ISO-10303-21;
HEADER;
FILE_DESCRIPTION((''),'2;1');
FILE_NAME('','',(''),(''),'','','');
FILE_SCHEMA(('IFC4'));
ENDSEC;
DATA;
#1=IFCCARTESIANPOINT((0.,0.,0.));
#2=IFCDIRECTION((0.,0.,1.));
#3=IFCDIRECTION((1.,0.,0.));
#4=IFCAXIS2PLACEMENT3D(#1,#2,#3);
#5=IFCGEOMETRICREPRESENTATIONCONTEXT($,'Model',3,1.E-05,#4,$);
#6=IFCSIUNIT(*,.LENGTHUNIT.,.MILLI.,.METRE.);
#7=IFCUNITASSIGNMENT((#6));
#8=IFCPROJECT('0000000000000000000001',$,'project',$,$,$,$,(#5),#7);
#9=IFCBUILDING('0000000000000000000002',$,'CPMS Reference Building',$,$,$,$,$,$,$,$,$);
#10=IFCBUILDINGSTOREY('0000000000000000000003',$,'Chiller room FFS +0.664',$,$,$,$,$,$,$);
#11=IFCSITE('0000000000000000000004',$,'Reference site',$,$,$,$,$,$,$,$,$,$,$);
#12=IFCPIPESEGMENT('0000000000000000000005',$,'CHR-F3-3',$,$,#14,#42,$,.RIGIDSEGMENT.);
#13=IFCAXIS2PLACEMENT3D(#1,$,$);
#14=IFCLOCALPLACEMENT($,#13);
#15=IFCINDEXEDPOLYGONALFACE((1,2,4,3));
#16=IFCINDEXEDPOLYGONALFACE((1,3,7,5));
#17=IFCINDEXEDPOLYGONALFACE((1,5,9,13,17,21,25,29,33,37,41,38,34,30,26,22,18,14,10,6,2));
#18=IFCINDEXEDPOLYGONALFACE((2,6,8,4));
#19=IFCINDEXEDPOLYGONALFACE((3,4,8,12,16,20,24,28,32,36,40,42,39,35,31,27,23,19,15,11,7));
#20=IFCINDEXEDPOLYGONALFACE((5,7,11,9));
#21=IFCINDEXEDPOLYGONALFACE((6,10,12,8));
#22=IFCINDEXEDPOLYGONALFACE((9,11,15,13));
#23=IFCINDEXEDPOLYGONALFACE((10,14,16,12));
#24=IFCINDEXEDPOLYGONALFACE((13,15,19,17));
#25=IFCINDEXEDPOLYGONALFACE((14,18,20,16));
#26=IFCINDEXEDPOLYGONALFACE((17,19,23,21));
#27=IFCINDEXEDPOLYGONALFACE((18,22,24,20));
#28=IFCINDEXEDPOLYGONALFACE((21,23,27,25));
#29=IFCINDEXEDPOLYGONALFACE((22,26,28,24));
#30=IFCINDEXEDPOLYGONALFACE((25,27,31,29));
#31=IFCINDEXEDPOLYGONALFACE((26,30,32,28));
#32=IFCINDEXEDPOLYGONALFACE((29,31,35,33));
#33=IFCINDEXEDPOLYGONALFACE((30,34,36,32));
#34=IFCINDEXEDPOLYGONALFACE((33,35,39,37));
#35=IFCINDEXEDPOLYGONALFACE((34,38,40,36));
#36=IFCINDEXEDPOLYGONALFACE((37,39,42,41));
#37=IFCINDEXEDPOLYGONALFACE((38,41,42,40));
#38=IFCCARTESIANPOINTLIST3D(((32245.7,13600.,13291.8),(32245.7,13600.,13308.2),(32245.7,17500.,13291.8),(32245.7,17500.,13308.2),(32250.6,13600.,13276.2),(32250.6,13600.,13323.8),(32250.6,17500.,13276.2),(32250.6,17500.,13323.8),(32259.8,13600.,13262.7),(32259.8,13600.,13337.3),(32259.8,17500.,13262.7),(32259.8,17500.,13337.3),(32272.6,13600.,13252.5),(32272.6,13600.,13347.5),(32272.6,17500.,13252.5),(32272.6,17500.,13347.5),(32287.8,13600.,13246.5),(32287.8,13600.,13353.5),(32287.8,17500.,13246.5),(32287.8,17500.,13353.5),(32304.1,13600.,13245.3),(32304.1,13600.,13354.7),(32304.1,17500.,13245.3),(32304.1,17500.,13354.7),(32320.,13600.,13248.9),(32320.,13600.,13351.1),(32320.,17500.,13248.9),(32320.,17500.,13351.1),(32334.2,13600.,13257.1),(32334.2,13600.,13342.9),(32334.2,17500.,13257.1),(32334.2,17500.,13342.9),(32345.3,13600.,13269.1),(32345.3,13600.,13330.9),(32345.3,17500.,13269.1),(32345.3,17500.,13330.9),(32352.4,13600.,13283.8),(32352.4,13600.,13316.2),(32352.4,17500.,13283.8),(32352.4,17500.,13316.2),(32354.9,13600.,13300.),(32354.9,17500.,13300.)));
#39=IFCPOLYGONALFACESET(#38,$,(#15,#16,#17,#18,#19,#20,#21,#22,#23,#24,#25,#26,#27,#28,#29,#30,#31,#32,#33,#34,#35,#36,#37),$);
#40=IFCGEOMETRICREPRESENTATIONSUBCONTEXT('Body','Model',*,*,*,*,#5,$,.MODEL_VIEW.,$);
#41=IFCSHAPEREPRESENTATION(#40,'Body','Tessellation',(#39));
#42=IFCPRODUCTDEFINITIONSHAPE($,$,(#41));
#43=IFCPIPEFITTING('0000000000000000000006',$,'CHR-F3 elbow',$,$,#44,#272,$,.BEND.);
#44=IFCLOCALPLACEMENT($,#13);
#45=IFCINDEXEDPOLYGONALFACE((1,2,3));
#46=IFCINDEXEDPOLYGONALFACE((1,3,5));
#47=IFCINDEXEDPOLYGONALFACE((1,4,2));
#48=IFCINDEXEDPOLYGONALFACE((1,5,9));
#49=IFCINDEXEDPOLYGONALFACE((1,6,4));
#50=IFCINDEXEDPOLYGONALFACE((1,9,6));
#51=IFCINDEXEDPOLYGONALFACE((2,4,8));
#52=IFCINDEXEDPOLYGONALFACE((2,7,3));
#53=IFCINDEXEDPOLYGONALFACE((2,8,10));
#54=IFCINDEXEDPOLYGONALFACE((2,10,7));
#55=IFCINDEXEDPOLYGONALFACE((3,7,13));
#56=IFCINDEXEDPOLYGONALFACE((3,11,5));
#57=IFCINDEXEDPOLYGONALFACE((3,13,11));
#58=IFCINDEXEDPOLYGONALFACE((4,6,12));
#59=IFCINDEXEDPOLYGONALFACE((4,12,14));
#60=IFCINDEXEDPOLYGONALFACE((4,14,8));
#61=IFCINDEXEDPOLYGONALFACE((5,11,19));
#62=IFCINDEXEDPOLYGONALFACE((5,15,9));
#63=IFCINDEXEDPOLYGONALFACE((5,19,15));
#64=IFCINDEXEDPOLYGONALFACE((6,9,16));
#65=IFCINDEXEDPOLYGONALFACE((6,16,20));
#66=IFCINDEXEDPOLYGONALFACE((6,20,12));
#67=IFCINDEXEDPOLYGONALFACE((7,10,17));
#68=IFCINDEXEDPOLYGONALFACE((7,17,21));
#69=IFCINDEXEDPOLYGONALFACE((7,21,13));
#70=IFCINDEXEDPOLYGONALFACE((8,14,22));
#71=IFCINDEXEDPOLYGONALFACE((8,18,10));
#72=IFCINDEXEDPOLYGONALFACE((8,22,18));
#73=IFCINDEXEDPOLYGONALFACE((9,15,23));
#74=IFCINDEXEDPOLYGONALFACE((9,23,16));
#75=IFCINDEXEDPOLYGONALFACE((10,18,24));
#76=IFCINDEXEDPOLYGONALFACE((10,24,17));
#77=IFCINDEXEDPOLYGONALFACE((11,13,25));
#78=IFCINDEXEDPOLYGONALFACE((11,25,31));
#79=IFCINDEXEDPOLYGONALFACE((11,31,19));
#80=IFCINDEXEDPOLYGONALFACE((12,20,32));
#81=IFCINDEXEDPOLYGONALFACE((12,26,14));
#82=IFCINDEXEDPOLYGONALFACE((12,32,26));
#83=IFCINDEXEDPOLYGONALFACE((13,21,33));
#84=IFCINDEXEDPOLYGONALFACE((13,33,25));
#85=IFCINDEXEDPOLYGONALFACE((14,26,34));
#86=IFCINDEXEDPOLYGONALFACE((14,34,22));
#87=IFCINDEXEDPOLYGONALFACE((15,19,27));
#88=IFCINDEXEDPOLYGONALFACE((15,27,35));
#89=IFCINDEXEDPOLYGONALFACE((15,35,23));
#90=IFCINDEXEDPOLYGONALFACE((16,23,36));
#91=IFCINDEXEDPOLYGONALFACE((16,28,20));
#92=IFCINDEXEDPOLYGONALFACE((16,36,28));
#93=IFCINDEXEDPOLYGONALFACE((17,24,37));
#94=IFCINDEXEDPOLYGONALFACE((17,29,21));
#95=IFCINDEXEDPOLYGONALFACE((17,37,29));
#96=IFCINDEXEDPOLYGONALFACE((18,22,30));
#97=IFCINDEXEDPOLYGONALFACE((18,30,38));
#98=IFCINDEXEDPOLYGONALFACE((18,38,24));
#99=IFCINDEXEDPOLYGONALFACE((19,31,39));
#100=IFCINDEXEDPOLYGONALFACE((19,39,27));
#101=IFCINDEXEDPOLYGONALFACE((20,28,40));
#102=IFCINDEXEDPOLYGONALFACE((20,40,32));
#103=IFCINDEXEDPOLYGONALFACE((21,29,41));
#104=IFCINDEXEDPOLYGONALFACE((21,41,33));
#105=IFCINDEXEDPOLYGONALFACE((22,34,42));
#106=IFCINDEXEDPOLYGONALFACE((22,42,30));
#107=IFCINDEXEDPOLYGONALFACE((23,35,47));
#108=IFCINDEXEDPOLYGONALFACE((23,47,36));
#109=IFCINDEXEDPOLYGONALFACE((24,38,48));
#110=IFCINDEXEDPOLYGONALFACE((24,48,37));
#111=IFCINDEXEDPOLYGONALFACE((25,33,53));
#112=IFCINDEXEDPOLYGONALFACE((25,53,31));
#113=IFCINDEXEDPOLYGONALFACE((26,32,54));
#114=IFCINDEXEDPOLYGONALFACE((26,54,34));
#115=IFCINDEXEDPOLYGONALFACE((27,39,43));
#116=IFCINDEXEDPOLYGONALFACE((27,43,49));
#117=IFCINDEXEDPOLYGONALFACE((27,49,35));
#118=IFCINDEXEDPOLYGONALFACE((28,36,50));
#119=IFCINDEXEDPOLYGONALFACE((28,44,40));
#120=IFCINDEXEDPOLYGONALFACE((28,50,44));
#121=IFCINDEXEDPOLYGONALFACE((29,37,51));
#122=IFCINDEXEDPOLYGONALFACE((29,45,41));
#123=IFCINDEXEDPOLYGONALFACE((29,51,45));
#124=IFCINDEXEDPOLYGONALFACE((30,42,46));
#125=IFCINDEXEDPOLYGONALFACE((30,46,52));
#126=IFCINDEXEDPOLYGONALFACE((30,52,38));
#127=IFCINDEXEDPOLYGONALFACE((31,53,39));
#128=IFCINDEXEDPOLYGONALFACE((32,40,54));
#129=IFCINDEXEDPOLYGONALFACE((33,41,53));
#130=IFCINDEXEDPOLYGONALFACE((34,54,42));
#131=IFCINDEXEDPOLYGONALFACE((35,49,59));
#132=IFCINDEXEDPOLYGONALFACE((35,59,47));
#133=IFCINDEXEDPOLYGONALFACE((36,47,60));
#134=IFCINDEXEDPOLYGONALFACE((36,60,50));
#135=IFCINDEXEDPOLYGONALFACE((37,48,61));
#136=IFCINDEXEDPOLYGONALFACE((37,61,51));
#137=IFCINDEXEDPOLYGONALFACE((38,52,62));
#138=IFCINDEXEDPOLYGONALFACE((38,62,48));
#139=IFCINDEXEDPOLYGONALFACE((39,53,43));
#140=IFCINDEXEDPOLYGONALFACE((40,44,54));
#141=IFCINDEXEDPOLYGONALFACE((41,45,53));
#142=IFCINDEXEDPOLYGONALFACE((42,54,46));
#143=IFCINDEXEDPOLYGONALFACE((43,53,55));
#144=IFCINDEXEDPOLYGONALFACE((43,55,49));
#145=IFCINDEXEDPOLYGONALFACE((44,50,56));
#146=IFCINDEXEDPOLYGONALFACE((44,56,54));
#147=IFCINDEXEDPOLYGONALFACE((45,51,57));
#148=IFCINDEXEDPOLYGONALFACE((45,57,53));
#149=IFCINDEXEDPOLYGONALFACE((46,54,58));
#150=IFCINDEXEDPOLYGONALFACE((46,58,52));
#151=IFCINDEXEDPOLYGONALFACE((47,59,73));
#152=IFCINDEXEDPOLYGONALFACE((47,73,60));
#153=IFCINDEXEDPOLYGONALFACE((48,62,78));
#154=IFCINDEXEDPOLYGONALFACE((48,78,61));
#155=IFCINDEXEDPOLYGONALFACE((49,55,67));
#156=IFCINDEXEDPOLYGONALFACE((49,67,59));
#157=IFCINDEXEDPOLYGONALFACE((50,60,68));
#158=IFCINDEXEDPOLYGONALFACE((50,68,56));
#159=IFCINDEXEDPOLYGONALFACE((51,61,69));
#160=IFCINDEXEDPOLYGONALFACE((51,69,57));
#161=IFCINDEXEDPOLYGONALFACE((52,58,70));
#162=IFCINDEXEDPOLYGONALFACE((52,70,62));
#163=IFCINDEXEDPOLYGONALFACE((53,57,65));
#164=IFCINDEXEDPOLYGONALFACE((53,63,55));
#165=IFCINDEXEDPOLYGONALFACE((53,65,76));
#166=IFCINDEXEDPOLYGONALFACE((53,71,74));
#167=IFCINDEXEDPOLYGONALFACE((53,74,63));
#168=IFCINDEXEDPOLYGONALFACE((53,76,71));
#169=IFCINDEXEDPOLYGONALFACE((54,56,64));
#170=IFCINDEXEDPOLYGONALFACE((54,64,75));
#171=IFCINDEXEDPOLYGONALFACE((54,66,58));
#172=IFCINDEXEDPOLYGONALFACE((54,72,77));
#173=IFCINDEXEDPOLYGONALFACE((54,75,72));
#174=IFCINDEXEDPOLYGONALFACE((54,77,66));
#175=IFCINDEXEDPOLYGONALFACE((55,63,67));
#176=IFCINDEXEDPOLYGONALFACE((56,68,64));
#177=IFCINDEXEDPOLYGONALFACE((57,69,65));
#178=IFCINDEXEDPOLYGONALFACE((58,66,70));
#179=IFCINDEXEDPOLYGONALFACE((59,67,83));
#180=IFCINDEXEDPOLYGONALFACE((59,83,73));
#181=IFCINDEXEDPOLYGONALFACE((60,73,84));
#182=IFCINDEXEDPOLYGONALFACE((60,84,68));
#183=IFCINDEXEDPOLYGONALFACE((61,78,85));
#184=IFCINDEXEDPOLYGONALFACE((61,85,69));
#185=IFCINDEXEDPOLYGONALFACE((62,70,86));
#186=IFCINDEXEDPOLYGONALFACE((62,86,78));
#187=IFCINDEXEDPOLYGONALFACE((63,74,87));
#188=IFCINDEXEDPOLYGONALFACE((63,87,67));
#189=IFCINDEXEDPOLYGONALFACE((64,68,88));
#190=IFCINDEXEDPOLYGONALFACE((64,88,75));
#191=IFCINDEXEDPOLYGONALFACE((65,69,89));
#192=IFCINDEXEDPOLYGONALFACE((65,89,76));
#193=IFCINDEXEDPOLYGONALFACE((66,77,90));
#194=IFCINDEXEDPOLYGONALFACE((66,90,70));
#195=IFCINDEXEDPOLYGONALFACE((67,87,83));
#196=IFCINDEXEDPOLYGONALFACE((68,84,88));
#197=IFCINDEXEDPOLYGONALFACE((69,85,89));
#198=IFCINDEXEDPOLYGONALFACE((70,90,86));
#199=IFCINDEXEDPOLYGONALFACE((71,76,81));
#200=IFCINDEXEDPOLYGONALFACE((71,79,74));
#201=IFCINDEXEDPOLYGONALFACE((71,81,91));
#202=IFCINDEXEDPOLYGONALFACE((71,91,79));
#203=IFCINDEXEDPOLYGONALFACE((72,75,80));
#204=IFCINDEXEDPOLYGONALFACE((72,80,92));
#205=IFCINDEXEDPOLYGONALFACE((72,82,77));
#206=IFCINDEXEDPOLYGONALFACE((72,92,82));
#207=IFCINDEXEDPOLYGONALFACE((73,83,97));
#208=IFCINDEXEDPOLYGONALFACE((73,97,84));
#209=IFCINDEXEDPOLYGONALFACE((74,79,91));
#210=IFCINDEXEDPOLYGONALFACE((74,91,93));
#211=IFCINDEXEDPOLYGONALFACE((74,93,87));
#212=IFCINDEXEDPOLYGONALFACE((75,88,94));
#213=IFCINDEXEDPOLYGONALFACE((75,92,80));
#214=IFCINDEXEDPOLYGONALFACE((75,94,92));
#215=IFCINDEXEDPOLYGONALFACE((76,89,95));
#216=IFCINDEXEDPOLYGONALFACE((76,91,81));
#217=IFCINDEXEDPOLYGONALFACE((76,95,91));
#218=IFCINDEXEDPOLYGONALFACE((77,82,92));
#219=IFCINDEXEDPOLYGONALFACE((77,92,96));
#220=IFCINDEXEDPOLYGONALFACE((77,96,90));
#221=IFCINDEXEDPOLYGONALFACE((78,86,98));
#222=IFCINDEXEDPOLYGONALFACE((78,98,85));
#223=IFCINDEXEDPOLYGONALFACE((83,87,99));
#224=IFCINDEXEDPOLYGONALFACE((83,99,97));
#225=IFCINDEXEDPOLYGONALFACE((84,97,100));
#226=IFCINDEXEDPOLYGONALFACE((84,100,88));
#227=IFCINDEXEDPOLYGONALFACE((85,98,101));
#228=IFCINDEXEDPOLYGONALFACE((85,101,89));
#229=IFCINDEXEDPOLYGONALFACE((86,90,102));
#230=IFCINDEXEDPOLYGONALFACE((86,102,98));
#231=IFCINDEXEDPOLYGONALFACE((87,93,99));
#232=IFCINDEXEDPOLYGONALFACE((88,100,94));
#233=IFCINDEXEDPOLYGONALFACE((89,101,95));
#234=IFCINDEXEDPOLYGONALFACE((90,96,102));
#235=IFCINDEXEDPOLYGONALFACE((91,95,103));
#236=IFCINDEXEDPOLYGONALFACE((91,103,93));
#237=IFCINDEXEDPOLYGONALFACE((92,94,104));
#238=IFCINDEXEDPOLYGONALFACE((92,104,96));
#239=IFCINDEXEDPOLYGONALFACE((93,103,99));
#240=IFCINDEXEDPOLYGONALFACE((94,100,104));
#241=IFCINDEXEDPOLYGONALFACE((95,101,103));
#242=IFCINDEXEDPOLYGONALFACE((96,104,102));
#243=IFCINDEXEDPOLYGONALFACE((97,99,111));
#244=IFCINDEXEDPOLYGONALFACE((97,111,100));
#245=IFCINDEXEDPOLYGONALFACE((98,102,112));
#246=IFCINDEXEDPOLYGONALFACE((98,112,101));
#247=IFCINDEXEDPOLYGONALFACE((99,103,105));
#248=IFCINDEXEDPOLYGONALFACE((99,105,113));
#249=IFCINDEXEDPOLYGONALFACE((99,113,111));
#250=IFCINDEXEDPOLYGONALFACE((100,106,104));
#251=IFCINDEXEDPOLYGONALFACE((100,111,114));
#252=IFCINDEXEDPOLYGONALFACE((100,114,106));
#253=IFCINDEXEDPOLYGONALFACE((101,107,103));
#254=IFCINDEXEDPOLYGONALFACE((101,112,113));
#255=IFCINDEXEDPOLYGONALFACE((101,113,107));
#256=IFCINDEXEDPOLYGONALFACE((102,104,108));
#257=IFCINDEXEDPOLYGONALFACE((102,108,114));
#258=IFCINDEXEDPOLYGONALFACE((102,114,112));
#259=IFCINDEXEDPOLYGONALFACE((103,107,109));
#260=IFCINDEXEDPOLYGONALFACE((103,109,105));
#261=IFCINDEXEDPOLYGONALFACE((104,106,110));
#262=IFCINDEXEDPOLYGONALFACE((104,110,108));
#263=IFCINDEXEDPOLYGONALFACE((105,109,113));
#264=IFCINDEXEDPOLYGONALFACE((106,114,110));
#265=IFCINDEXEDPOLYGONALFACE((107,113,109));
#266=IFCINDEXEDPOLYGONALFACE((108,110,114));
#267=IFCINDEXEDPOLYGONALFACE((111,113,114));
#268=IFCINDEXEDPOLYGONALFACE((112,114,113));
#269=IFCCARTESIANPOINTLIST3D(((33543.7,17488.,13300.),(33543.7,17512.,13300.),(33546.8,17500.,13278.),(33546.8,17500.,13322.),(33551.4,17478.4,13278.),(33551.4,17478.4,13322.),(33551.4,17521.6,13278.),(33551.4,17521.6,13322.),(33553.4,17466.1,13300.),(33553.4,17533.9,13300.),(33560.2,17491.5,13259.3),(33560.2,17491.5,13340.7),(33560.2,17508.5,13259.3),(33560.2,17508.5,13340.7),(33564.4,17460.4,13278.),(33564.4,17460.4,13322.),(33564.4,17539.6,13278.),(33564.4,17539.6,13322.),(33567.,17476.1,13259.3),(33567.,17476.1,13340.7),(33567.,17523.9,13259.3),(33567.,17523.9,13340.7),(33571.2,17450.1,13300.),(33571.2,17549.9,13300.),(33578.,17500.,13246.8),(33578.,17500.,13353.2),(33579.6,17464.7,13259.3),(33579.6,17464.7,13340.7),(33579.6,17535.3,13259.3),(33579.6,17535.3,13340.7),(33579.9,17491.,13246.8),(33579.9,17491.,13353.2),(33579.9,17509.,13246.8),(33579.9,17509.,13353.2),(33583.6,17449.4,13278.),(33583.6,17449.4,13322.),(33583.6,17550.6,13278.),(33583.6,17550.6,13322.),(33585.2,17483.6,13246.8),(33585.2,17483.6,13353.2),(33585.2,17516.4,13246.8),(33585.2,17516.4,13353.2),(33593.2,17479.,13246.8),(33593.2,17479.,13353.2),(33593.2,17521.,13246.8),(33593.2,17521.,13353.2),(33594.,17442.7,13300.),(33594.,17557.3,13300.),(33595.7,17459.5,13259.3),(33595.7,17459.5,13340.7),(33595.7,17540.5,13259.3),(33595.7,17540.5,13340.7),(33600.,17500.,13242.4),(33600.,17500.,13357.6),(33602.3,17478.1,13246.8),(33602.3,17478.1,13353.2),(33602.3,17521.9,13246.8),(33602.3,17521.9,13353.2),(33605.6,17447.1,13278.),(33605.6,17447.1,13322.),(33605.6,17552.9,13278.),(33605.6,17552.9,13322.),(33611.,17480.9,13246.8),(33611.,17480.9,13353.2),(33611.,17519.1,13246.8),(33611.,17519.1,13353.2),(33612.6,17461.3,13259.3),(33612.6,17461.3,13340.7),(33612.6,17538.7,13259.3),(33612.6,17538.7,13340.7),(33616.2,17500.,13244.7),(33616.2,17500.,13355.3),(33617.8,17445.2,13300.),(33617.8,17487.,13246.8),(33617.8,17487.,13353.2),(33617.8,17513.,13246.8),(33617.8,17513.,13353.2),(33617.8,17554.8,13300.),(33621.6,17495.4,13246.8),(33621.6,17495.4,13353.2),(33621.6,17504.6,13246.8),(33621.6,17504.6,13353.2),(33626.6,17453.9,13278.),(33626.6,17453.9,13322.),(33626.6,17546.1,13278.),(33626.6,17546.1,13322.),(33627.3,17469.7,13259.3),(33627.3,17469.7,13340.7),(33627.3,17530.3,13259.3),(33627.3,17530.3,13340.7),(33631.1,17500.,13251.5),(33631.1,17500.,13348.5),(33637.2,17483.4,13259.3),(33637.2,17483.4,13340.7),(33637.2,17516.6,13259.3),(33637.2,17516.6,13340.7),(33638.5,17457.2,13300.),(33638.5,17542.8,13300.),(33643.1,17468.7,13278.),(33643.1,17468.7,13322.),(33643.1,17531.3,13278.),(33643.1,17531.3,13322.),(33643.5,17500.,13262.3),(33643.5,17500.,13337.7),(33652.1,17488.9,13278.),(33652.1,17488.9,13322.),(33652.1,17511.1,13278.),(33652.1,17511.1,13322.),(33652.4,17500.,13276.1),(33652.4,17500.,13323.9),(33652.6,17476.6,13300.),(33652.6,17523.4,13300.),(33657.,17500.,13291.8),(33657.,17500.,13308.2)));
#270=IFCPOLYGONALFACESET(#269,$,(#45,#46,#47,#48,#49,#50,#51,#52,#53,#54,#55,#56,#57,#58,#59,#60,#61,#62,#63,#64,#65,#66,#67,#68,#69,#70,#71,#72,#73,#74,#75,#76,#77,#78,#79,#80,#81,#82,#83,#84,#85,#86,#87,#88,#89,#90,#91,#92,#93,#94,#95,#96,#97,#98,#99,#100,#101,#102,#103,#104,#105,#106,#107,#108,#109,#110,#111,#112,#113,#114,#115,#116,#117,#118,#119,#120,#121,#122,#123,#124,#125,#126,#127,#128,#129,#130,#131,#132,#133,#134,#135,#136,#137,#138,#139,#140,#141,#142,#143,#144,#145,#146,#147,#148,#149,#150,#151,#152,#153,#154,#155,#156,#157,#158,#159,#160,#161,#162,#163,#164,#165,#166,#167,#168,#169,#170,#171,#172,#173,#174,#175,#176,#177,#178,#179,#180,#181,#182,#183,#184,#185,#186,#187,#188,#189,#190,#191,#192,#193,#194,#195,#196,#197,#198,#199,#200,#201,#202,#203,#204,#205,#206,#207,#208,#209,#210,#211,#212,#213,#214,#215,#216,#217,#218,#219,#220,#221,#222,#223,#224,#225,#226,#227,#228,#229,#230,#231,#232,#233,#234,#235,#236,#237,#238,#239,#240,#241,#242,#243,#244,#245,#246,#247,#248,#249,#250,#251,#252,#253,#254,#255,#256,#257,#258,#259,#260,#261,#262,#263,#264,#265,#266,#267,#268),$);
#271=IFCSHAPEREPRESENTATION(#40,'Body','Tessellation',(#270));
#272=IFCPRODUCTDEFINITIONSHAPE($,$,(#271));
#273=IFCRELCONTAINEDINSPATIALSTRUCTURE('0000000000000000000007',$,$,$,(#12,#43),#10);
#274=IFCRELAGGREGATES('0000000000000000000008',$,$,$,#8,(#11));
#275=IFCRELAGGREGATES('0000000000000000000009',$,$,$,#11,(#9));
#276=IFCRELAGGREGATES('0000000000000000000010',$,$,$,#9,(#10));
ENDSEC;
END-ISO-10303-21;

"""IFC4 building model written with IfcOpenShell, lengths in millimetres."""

from ifc_helpers import new_model, entity, si_unit, frame, origin_with_axes, origin_2d, place, context, subcontext, project, spatial, circle_curve, outline, extrude, element, save


model = new_model("IFC4")

# Units and contexts
model_context = context("Model", 3, precision=1e-05, world=origin_with_axes())
body_context = subcontext(model_context, "Body", "Model", "MODEL_VIEW")
ifc_project = project(units=[si_unit("LENGTHUNIT", "METRE", prefix="MILLI")], contexts=[model_context])

# Site, building, storey
site = spatial("IfcSite", under=ifc_project, Name="Reference site")
building = spatial("IfcBuilding", under=site, Name="CPMS Reference Building")
storey = spatial("IfcBuildingStorey", under=building, Name="Chiller room FFS +0.664")

# Pipe segment
pipe_segment_1_placement = place(None, origin_with_axes())
element("IfcPipeSegment", 1, at=pipe_segment_1_placement, inside=storey, Name="CHR-F3-3", PredefinedType="RIGIDSEGMENT", context=body_context, shape_type="SweptSolid", body=[
    extrude(outline(circle_curve(origin_2d(), 54.9)), frame((32300.0, 17500.0, 13300.0), z_axis=(0.0, -1.0, 0.0), x_axis=(1.0, 0.0, 0.0)), (0.0, 0.0, 1.0), 3900.0),
])

# Pipe fitting
pipe_fitting_1_placement = place(None, origin_with_axes())
element("IfcPipeFitting", 2, at=pipe_fitting_1_placement, inside=storey, Name="CHR-F3 elbow", PredefinedType="BEND", context=body_context, shape_type="CSG", body=[
    entity("IfcSphere", entity("IfcAxis2Placement3D", entity("IfcCartesianPoint", [33600.0, 17500.0, 13300.0]), entity("IfcDirection", [0.0, 0.0, 1.0]), entity("IfcDirection", [1.0, 0.0, 0.0])), 57.6),
])

save(model, "model.ifc")
